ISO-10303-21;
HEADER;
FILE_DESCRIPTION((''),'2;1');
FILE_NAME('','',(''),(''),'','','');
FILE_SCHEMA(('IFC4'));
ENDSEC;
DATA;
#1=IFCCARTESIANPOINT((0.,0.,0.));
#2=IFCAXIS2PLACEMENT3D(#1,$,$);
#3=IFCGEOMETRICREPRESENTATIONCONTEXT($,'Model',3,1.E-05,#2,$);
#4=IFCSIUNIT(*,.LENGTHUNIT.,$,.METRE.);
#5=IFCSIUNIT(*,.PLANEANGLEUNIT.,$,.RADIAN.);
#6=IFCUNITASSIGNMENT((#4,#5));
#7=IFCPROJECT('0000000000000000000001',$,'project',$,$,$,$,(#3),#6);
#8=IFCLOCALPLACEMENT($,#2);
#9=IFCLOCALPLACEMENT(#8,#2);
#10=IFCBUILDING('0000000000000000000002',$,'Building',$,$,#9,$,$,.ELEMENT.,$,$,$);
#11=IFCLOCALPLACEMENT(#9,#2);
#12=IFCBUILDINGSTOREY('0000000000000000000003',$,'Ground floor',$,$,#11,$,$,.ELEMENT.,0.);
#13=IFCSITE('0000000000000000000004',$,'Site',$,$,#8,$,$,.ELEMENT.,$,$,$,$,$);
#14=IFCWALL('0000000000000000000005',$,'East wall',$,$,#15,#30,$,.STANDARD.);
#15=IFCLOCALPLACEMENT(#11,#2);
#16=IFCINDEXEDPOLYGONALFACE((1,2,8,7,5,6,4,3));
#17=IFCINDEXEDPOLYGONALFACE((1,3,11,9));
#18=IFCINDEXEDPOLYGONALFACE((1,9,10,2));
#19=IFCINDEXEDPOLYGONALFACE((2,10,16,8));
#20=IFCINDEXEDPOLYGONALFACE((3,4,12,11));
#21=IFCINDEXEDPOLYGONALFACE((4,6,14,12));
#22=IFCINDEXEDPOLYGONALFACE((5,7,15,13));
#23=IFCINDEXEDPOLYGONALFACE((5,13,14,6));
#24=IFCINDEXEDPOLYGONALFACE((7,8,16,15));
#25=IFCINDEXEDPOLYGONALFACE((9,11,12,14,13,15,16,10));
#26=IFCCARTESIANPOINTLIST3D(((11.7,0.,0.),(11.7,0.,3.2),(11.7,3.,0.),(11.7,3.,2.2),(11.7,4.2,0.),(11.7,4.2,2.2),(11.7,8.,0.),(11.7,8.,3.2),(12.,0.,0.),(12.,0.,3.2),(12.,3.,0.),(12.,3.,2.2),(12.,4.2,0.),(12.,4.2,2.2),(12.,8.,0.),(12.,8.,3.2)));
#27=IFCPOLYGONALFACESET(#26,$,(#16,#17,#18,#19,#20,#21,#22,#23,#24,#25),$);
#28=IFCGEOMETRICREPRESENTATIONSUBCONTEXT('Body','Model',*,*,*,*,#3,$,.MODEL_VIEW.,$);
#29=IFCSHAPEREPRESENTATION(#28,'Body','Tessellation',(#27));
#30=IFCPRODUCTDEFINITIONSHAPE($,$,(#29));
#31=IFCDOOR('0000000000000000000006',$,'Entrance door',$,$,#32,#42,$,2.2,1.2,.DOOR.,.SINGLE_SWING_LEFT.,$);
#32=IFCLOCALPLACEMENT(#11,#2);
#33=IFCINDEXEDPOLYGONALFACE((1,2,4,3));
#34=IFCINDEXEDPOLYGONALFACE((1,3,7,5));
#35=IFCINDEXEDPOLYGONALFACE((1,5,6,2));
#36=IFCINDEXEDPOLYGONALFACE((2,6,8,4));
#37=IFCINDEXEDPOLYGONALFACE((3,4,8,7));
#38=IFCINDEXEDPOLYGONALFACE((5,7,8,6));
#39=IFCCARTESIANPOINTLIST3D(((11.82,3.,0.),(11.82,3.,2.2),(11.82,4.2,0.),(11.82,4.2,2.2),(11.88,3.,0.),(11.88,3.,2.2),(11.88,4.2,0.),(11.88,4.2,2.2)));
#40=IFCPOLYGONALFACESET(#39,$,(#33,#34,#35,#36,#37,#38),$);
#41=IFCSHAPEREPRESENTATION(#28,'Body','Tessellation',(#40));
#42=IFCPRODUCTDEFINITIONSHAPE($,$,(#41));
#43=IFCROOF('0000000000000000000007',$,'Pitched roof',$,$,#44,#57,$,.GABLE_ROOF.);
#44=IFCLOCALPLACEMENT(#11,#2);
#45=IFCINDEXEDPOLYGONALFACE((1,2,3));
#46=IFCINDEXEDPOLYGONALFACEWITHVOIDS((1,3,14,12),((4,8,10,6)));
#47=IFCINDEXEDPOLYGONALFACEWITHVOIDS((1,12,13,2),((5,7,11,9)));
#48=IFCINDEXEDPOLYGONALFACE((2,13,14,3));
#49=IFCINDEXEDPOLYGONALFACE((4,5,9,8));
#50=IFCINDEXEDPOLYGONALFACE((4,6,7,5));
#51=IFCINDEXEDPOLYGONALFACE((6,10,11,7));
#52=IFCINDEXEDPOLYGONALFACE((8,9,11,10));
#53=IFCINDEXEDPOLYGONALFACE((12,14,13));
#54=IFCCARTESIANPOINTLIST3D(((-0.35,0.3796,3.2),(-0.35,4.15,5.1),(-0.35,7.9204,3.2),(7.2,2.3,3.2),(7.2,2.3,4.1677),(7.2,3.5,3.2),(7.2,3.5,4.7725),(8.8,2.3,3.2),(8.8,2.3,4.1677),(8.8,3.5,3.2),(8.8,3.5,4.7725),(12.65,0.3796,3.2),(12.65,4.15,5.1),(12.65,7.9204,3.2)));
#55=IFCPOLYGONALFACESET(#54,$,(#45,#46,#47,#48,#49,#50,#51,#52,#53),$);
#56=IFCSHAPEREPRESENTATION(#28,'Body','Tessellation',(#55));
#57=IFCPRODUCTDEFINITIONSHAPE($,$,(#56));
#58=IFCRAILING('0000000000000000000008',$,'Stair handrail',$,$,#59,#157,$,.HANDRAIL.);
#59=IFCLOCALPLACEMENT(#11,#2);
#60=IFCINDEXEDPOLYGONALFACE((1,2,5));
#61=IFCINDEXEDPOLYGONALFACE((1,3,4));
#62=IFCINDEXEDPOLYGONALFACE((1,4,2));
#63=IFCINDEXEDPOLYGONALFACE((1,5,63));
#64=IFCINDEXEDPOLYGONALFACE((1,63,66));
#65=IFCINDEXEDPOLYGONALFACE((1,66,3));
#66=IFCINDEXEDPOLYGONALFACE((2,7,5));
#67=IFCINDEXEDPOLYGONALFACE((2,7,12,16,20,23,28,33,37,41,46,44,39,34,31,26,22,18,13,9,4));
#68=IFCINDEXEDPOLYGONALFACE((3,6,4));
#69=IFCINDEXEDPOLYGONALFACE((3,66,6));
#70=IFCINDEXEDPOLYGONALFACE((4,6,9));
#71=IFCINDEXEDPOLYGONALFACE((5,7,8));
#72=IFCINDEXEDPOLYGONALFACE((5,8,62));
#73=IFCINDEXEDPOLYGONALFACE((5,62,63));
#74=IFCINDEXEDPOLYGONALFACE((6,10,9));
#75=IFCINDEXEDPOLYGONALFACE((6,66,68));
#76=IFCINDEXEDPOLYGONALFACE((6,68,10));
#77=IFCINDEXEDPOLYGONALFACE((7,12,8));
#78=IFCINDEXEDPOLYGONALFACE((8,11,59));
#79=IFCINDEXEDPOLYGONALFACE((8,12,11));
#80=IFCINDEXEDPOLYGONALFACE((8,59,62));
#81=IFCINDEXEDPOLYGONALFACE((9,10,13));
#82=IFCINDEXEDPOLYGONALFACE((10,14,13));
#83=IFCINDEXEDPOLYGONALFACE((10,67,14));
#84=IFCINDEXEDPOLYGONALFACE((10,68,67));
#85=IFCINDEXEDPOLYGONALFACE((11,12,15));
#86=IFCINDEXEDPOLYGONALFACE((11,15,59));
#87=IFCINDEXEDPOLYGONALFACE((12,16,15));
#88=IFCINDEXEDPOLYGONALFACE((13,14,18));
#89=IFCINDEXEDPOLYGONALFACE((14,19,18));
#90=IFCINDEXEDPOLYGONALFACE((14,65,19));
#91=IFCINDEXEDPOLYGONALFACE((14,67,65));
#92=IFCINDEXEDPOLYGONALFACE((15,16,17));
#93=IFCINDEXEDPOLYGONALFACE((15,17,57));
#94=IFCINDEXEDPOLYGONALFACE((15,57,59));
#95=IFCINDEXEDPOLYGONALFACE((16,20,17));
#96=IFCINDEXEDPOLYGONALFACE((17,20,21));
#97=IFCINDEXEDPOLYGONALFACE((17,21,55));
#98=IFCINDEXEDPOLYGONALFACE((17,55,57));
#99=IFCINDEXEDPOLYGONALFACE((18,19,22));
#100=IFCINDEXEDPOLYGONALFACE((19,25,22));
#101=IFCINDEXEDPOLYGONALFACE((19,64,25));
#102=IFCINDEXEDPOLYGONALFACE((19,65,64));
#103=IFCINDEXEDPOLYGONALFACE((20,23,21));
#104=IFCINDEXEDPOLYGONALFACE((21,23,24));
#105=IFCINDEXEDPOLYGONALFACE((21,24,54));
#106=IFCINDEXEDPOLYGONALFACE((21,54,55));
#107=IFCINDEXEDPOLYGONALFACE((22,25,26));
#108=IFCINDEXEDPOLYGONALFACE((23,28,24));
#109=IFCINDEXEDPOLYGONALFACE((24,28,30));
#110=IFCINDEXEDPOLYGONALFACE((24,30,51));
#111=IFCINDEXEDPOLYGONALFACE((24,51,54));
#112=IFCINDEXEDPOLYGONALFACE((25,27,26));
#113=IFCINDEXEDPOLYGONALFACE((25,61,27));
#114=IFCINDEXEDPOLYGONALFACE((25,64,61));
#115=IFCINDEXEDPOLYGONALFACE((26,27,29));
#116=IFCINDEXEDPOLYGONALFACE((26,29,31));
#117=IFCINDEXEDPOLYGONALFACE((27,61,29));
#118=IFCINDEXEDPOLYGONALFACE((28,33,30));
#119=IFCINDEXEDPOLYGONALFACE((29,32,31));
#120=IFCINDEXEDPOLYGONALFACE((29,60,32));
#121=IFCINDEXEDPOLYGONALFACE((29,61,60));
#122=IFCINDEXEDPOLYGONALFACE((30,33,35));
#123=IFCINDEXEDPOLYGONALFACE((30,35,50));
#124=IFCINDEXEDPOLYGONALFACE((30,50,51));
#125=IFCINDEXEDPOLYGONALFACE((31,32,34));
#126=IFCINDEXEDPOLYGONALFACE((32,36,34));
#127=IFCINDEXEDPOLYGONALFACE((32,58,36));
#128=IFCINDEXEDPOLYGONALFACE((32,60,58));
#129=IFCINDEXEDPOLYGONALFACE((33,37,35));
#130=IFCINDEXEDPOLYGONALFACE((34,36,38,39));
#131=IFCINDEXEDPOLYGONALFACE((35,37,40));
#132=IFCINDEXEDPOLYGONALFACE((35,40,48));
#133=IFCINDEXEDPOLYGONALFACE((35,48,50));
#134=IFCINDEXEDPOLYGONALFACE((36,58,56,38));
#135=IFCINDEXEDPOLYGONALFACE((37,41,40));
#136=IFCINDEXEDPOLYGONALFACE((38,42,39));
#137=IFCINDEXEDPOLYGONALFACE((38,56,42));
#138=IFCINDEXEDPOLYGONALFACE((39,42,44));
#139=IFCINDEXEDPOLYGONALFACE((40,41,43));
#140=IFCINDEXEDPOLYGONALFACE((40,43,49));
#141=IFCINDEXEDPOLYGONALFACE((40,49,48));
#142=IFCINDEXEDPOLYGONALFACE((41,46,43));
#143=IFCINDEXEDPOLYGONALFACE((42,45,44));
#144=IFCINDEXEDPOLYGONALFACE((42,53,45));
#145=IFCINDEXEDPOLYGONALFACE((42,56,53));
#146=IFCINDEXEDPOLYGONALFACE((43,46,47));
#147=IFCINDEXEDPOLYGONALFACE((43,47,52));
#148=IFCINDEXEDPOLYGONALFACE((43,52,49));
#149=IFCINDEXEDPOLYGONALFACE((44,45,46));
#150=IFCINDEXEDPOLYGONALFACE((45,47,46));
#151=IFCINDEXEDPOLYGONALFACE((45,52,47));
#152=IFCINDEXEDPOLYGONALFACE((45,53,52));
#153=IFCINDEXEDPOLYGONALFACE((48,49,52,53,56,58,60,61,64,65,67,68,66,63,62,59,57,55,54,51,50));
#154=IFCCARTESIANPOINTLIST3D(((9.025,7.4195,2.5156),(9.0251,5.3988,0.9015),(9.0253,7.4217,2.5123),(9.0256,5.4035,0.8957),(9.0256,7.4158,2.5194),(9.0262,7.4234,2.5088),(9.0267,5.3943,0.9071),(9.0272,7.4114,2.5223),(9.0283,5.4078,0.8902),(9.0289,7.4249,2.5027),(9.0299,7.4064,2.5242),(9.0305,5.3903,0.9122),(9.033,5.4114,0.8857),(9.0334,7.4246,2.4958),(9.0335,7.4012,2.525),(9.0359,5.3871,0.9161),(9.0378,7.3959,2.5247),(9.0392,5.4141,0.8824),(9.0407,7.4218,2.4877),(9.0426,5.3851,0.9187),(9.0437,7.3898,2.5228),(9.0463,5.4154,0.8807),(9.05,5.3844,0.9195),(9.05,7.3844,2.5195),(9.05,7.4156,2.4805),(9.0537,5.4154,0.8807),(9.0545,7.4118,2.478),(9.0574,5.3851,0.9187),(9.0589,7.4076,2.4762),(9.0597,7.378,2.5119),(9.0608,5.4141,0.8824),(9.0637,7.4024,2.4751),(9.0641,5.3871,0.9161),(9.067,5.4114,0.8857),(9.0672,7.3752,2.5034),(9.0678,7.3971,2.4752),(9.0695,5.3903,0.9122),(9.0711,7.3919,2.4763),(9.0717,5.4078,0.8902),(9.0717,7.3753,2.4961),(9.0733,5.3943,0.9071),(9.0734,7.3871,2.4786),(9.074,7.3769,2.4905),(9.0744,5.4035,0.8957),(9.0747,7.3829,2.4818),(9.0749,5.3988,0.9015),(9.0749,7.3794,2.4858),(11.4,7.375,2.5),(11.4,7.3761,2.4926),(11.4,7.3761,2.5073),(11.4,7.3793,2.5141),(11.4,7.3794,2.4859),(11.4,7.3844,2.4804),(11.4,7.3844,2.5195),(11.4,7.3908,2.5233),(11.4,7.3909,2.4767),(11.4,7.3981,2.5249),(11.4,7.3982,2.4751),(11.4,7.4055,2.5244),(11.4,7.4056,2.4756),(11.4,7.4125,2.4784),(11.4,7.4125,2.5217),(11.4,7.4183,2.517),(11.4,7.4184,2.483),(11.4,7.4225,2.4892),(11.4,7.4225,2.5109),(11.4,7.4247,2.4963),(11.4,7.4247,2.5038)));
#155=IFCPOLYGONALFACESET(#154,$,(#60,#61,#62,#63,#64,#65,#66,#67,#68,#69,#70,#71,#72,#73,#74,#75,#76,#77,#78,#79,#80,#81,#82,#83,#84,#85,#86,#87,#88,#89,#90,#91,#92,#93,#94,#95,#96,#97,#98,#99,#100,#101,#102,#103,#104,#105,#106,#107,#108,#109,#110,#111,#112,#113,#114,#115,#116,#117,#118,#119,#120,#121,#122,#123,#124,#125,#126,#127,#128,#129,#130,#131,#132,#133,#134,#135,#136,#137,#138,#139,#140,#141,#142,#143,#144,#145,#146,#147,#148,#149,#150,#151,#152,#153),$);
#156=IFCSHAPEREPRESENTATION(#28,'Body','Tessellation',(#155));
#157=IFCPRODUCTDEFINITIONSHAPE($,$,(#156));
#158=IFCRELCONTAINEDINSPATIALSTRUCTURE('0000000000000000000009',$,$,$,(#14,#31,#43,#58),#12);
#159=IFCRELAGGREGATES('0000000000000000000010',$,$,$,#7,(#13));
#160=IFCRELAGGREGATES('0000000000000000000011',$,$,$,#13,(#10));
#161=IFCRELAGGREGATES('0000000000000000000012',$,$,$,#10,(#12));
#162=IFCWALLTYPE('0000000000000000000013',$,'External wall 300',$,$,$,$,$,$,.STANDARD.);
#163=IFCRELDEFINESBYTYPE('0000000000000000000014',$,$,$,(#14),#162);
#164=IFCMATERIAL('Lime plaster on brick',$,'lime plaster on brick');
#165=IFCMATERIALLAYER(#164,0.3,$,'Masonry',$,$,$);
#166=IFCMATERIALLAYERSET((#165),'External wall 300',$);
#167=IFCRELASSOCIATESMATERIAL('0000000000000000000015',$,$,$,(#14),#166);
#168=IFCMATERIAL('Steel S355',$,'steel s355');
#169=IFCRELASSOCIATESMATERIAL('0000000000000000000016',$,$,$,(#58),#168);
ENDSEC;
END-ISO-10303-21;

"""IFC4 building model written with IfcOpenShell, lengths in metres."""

from ifc_helpers import new_model, entity, si_unit, frame, frame_2d, origin, place, context, subcontext, project, spatial, rectangle, extrude, boolean, clip, halfspace, material, layer, layer_set, layer_usage, type_object, element, save


model = new_model("IFC4")

# Units and contexts
model_context = context("Model", 3, precision=1e-05, world=origin())
body_context = subcontext(model_context, "Body", "Model", "MODEL_VIEW")
ifc_project = project(units=[si_unit("LENGTHUNIT", "METRE"), si_unit("PLANEANGLEUNIT", "RADIAN")], contexts=[model_context])

# Site, building, storey
site_placement = place(None, origin())
site = spatial("IfcSite", under=ifc_project, at=site_placement, Name="Site", CompositionType="ELEMENT")
building_placement = place(site_placement, origin())
building = spatial("IfcBuilding", under=site, at=building_placement, Name="Building", CompositionType="ELEMENT")
storey_placement = place(building_placement, origin())
storey = spatial("IfcBuildingStorey", under=building, at=storey_placement, Name="Ground floor", CompositionType="ELEMENT", Elevation=0.0)

# Shared definitions
ifc_material_1 = material(Name="Steel S355", Category="steel s355")

# Shared definitions
ifc_material_2 = material(Name="Lime plaster on brick", Category="lime plaster on brick")
ifc_layer = layer(ifc_material_2, 0.3, Name="Masonry")
ifc_layer_set = layer_set([ifc_layer], Name="External wall 300")
ifc_layer_usage = layer_usage(ifc_layer_set, "AXIS2", "POSITIVE", 0.0)
wall_type = type_object("IfcWallType", Name="External wall 300", PredefinedType="STANDARD")

# Wall, opening
wall_1_placement = place(storey_placement, frame((12.0, 0.0, 0.0), z_axis=(0.0, 0.0, 1.0), x_axis=(0.0, 1.0, 0.0)))
wall_1 = element("IfcWall", 1, at=wall_1_placement, inside=storey, type_object=wall_type, material=ifc_layer_usage, Name="East wall", PredefinedType="STANDARD", context=body_context, shape_type="SweptSolid", body=[
    extrude(rectangle(XDim=8.0, YDim=0.3, at=frame_2d((4.0, 0.15))), origin(), (0.0, 0.0, 1.0), 3.2),
])
opening_1_placement = place(wall_1_placement, frame((3.0, -0.1, 0.0)))
element("IfcOpeningElement", 2, at=opening_1_placement, cuts=wall_1, PredefinedType="OPENING", context=body_context, shape_type="SweptSolid", body=[
    extrude(rectangle(XDim=1.2, YDim=0.5, at=frame_2d((0.6, 0.25))), origin(), (0.0, 0.0, 1.0), 2.2),
])

# Door
door_placement = place(storey_placement, frame((12.0, 3.0, 0.0), z_axis=(0.0, 0.0, 1.0), x_axis=(0.0, 1.0, 0.0)))
element("IfcDoor", 3, at=door_placement, inside=storey, Name="Entrance door", OperationType="SINGLE_SWING_LEFT", OverallHeight=2.2, OverallWidth=1.2, PredefinedType="DOOR", context=body_context, shape_type="SweptSolid", body=[
    extrude(rectangle(XDim=1.2, YDim=0.06, at=frame_2d((0.6, 0.03))), frame((0.0, 0.12, 0.0)), (0.0, 0.0, 1.0), 2.2),
])

# Roof
roof_placement = place(storey_placement, frame((0.0, 0.0, 3.2)))
element("IfcRoof", 4, at=roof_placement, inside=storey, Name="Pitched roof", PredefinedType="GABLE_ROOF", context=body_context, shape_type="Clipping", body=[
    boolean("DIFFERENCE", clip(clip(extrude(rectangle(XDim=13.0, YDim=9.0, at=frame_2d((6.5, 4.5))), frame((-0.35, -0.35, 0.0)), (0.0, 0.0, 1.0), 2.2), halfspace(frame((0.0, 4.15, 1.9), z_axis=(0.0, 0.45, 0.893), x_axis=(1.0, 0.0, 0.0)), False)), halfspace(frame((0.0, 4.15, 1.9), z_axis=(0.0, -0.45, 0.893), x_axis=(1.0, 0.0, 0.0)), False)), extrude(rectangle(XDim=1.6, YDim=1.2, at=frame_2d((0.8, 0.6))), frame((7.2, 2.3, -0.5)), (0.0, 0.0, 1.0), 3.0)),
])

# Railing
railing_placement = place(storey_placement, origin())
element("IfcRailing", 5, at=railing_placement, inside=storey, material=ifc_material_1, Name="Stair handrail", PredefinedType="HANDRAIL", context=body_context, shape_type="AdvancedSweptSolid", body=[
    entity("IfcSweptDiskSolid", entity("IfcPolyline", [entity("IfcCartesianPoint", [9.05, 5.4, 0.9]), entity("IfcCartesianPoint", [9.05, 7.4, 2.5]), entity("IfcCartesianPoint", [11.4, 7.4, 2.5])]), 0.025),
])

save(model, "model.ifc")
